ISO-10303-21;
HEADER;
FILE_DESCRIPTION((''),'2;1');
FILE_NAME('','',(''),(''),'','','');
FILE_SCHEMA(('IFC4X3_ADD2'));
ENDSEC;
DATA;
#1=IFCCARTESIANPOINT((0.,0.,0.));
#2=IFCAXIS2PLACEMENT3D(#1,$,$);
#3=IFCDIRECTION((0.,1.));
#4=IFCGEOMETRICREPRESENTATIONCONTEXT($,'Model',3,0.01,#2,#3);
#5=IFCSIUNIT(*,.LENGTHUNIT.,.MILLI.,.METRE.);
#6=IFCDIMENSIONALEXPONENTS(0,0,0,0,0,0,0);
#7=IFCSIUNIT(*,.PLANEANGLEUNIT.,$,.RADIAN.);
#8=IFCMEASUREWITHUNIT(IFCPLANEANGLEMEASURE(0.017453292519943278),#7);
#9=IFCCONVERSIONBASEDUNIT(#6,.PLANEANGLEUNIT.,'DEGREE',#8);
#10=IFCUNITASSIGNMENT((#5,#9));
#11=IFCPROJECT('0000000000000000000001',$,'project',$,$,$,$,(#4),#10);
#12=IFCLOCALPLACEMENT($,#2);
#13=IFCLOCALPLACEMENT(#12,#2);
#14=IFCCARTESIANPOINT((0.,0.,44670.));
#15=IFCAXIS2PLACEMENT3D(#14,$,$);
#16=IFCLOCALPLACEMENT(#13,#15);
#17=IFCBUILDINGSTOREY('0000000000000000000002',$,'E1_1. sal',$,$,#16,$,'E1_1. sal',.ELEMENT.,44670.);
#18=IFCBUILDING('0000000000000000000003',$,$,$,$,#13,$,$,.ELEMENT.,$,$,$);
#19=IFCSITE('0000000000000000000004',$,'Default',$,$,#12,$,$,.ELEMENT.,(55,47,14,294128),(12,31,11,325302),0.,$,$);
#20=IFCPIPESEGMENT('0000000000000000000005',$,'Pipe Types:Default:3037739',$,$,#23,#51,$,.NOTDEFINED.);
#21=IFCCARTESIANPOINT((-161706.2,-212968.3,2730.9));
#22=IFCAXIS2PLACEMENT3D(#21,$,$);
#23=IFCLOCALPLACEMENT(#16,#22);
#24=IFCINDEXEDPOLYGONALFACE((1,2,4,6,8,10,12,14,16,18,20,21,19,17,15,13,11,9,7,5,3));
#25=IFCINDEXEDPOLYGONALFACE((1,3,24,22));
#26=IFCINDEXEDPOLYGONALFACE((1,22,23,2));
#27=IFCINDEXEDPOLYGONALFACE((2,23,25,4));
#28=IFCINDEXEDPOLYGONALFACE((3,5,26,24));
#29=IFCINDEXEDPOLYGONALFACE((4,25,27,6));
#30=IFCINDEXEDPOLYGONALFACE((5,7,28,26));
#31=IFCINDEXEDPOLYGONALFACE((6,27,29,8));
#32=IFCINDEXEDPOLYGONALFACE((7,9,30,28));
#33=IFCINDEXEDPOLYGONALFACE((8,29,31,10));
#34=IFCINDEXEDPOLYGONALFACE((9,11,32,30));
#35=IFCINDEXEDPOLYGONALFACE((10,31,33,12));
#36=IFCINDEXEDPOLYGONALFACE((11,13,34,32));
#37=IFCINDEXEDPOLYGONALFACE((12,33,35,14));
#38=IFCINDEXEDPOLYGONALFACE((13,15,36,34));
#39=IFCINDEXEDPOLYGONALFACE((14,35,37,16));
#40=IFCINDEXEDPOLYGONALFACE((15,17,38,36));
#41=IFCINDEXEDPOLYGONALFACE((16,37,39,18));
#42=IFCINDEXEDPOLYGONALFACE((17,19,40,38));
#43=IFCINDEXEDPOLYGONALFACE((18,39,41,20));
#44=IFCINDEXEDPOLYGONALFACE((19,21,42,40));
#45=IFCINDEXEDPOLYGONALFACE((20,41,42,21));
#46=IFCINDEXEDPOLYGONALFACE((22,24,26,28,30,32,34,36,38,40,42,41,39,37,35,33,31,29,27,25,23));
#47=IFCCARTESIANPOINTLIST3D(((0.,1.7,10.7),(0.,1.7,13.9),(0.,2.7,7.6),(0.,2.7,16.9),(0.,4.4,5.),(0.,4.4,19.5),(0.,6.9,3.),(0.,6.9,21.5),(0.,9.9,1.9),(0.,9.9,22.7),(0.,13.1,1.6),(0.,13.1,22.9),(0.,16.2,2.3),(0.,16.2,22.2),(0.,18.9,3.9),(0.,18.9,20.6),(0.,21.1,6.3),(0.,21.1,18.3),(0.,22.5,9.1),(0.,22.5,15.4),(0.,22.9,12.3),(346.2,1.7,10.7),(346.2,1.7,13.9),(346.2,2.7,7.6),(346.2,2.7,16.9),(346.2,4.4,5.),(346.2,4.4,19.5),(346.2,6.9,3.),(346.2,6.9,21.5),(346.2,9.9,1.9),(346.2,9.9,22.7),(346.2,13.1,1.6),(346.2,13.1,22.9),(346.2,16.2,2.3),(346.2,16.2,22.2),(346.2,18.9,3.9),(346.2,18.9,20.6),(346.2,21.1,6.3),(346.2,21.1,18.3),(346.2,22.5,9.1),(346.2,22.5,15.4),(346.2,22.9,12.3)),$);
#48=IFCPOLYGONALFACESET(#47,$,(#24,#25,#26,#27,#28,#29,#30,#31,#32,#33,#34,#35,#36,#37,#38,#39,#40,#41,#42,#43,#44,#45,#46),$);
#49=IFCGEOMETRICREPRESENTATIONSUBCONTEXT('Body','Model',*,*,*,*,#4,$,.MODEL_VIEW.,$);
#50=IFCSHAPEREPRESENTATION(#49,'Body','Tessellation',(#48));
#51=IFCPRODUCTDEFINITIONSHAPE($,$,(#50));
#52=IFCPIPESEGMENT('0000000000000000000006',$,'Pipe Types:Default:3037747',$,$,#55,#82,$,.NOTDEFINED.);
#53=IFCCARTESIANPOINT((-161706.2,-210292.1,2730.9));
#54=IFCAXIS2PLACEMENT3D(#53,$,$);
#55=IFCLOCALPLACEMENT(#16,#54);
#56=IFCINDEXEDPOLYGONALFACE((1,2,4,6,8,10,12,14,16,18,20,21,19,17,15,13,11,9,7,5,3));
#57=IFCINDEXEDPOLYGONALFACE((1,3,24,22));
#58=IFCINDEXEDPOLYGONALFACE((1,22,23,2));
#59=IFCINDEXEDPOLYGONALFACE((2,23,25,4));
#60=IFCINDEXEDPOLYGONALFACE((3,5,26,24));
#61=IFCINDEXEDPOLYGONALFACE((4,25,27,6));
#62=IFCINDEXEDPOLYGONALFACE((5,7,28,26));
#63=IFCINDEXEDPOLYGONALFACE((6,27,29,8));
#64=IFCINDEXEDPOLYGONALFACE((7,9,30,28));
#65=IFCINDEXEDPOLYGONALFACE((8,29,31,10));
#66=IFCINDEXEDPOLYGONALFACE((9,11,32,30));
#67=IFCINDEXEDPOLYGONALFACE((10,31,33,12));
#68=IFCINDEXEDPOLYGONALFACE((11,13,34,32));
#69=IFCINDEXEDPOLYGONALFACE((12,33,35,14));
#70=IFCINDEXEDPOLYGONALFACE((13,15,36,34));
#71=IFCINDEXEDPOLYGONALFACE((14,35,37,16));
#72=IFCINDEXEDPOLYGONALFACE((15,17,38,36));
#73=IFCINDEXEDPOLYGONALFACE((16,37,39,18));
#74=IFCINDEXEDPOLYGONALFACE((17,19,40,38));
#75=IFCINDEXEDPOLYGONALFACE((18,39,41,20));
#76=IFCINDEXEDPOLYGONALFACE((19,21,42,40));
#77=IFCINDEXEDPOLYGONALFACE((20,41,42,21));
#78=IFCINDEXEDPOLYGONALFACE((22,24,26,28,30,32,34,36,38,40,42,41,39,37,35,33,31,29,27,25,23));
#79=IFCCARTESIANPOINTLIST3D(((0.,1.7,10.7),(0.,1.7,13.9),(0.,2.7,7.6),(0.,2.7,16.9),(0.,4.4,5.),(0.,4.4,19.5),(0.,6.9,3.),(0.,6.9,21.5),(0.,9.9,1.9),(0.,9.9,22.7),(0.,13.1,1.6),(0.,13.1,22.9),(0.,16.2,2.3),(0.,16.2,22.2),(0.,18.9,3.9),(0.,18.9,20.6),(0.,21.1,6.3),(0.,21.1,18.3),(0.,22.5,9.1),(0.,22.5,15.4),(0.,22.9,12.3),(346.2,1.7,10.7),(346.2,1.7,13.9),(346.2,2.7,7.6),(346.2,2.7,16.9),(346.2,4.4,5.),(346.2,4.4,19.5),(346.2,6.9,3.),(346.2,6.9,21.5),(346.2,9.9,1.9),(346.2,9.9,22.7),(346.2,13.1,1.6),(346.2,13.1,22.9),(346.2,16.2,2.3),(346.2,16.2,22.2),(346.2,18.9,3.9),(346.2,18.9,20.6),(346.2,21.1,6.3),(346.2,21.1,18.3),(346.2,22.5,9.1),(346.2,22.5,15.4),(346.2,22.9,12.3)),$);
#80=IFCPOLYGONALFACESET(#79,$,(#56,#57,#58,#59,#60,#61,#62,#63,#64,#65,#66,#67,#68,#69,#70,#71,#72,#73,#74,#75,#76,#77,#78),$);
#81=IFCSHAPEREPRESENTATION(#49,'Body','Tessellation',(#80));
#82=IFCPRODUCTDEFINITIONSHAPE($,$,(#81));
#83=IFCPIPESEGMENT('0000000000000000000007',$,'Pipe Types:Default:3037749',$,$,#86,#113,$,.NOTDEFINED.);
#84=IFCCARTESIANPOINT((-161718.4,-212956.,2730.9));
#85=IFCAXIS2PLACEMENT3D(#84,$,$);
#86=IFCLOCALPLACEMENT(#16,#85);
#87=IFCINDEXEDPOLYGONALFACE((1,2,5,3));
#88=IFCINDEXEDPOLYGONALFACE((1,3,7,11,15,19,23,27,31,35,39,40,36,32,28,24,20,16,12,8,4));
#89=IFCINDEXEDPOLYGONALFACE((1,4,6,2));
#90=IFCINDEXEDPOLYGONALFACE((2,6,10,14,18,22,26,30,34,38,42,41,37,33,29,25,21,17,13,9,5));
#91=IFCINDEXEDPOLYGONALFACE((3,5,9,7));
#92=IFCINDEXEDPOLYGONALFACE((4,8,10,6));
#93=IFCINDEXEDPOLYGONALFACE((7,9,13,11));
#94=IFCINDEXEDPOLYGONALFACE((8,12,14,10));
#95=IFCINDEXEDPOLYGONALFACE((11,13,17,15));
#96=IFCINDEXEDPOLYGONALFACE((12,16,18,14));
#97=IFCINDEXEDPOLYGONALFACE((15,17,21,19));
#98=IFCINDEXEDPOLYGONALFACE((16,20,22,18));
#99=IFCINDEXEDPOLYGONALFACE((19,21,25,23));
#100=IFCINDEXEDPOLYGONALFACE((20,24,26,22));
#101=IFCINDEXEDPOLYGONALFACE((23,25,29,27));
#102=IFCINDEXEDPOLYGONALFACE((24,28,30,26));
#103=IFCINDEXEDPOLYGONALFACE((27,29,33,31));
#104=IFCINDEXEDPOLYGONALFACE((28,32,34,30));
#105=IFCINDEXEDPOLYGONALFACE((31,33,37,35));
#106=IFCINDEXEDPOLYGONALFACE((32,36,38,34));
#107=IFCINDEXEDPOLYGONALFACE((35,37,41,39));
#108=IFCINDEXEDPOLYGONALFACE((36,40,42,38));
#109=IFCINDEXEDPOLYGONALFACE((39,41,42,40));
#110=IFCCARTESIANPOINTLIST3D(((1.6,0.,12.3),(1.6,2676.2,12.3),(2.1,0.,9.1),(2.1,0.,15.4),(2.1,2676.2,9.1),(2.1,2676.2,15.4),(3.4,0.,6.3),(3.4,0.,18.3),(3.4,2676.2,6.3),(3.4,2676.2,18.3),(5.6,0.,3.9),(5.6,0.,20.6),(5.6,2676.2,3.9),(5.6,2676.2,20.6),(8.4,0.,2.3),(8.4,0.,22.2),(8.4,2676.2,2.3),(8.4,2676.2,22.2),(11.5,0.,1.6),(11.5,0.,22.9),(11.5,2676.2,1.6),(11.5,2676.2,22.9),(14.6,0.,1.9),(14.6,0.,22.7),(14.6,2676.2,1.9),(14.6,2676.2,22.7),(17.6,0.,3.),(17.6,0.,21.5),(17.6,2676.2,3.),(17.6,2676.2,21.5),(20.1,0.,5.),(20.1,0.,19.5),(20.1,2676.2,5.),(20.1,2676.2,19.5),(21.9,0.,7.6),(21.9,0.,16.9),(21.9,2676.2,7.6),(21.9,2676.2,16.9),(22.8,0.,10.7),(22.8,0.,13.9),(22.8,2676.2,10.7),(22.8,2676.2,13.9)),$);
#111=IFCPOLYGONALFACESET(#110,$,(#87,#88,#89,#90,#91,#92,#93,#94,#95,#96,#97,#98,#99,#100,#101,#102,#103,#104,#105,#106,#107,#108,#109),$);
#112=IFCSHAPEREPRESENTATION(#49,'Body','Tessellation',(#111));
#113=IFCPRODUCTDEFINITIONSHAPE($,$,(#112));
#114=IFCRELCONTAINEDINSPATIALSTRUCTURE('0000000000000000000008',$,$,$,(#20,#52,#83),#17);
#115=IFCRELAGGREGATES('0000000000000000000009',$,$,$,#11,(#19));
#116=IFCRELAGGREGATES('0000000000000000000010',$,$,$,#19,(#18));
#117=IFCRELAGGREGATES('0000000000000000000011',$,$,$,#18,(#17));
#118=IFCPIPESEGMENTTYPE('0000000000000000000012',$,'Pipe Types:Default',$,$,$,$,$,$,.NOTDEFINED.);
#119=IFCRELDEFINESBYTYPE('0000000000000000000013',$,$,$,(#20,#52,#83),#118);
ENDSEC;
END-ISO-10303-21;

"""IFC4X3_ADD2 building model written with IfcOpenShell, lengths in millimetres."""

from ifc_helpers import new_model, entity, si_unit, converted_unit, direction, frame, origin, origin_2d_with_axis, place, context, subcontext, project, spatial, circle, extrude, type_object, element, save


model = new_model("IFC4X3_ADD2")

# Units and contexts
model_context = context("Model", 3, precision=0.01, world=origin(), true_north=direction((0.0, 1.0)))
body_context = subcontext(model_context, "Body", "Model", "MODEL_VIEW")
ifc_project = project(units=[si_unit("LENGTHUNIT", "METRE", prefix="MILLI"), converted_unit("PLANEANGLEUNIT", "DEGREE", entity("IfcPlaneAngleMeasure", 0.017453292519943278), si_unit("PLANEANGLEUNIT", "RADIAN"), dimensions=[0, 0, 0, 0, 0, 0, 0])], contexts=[model_context])

# Site, building, storey
site_placement = place(None, origin())
site = spatial("IfcSite", under=ifc_project, at=site_placement, Name="Default", CompositionType="ELEMENT", RefLatitude=(55, 47, 14, 294128), RefLongitude=(12, 31, 11, 325302), RefElevation=0.0)
building_placement = place(site_placement, origin())
building = spatial("IfcBuilding", under=site, at=building_placement, CompositionType="ELEMENT")
storey_placement = place(building_placement, frame((0.0, 0.0, 44670.0)))
storey = spatial("IfcBuildingStorey", under=building, at=storey_placement, Name="E1_1. sal", LongName="E1_1. sal", CompositionType="ELEMENT", Elevation=44670.0)

# Pipe segments
pipe_segment_type = type_object("IfcPipeSegmentType", Name="Pipe Types:Default", PredefinedType="NOTDEFINED")
for number, where, name in (
    (1, (-161706.2, -212968.3, 2730.9), "Pipe Types:Default:3037739"),
    (2, (-161706.2, -210292.1, 2730.9), "Pipe Types:Default:3037747"),
):
    element("IfcPipeSegment", number, at=place(storey_placement, frame(where)), inside=storey, type_object=pipe_segment_type, Name=name, PredefinedType="NOTDEFINED", context=body_context, shape_type="SweptSolid", body=[
        extrude(circle(Radius=10.7, at=origin_2d_with_axis()), frame((0.0, 12.3, 12.3), z_axis=(1.0, 0.0, 0.0), x_axis=(0.0, 1.0, 0.0)), (0.0, 0.0, 1.0), 346.2),
    ])
pipe_segment_1_placement = place(storey_placement, frame((-161718.4, -212956.0, 2730.9)))
element("IfcPipeSegment", 3, at=pipe_segment_1_placement, inside=storey, type_object=pipe_segment_type, Name="Pipe Types:Default:3037749", PredefinedType="NOTDEFINED", context=body_context, shape_type="SweptSolid", body=[
    extrude(circle(Radius=10.7, at=origin_2d_with_axis()), frame((12.3, 0.0, 12.3), z_axis=(0.0, 1.0, 0.0), x_axis=(-1.0, 0.0, 0.0)), (0.0, 0.0, 1.0), 2676.2),
])

save(model, "model.ifc")
